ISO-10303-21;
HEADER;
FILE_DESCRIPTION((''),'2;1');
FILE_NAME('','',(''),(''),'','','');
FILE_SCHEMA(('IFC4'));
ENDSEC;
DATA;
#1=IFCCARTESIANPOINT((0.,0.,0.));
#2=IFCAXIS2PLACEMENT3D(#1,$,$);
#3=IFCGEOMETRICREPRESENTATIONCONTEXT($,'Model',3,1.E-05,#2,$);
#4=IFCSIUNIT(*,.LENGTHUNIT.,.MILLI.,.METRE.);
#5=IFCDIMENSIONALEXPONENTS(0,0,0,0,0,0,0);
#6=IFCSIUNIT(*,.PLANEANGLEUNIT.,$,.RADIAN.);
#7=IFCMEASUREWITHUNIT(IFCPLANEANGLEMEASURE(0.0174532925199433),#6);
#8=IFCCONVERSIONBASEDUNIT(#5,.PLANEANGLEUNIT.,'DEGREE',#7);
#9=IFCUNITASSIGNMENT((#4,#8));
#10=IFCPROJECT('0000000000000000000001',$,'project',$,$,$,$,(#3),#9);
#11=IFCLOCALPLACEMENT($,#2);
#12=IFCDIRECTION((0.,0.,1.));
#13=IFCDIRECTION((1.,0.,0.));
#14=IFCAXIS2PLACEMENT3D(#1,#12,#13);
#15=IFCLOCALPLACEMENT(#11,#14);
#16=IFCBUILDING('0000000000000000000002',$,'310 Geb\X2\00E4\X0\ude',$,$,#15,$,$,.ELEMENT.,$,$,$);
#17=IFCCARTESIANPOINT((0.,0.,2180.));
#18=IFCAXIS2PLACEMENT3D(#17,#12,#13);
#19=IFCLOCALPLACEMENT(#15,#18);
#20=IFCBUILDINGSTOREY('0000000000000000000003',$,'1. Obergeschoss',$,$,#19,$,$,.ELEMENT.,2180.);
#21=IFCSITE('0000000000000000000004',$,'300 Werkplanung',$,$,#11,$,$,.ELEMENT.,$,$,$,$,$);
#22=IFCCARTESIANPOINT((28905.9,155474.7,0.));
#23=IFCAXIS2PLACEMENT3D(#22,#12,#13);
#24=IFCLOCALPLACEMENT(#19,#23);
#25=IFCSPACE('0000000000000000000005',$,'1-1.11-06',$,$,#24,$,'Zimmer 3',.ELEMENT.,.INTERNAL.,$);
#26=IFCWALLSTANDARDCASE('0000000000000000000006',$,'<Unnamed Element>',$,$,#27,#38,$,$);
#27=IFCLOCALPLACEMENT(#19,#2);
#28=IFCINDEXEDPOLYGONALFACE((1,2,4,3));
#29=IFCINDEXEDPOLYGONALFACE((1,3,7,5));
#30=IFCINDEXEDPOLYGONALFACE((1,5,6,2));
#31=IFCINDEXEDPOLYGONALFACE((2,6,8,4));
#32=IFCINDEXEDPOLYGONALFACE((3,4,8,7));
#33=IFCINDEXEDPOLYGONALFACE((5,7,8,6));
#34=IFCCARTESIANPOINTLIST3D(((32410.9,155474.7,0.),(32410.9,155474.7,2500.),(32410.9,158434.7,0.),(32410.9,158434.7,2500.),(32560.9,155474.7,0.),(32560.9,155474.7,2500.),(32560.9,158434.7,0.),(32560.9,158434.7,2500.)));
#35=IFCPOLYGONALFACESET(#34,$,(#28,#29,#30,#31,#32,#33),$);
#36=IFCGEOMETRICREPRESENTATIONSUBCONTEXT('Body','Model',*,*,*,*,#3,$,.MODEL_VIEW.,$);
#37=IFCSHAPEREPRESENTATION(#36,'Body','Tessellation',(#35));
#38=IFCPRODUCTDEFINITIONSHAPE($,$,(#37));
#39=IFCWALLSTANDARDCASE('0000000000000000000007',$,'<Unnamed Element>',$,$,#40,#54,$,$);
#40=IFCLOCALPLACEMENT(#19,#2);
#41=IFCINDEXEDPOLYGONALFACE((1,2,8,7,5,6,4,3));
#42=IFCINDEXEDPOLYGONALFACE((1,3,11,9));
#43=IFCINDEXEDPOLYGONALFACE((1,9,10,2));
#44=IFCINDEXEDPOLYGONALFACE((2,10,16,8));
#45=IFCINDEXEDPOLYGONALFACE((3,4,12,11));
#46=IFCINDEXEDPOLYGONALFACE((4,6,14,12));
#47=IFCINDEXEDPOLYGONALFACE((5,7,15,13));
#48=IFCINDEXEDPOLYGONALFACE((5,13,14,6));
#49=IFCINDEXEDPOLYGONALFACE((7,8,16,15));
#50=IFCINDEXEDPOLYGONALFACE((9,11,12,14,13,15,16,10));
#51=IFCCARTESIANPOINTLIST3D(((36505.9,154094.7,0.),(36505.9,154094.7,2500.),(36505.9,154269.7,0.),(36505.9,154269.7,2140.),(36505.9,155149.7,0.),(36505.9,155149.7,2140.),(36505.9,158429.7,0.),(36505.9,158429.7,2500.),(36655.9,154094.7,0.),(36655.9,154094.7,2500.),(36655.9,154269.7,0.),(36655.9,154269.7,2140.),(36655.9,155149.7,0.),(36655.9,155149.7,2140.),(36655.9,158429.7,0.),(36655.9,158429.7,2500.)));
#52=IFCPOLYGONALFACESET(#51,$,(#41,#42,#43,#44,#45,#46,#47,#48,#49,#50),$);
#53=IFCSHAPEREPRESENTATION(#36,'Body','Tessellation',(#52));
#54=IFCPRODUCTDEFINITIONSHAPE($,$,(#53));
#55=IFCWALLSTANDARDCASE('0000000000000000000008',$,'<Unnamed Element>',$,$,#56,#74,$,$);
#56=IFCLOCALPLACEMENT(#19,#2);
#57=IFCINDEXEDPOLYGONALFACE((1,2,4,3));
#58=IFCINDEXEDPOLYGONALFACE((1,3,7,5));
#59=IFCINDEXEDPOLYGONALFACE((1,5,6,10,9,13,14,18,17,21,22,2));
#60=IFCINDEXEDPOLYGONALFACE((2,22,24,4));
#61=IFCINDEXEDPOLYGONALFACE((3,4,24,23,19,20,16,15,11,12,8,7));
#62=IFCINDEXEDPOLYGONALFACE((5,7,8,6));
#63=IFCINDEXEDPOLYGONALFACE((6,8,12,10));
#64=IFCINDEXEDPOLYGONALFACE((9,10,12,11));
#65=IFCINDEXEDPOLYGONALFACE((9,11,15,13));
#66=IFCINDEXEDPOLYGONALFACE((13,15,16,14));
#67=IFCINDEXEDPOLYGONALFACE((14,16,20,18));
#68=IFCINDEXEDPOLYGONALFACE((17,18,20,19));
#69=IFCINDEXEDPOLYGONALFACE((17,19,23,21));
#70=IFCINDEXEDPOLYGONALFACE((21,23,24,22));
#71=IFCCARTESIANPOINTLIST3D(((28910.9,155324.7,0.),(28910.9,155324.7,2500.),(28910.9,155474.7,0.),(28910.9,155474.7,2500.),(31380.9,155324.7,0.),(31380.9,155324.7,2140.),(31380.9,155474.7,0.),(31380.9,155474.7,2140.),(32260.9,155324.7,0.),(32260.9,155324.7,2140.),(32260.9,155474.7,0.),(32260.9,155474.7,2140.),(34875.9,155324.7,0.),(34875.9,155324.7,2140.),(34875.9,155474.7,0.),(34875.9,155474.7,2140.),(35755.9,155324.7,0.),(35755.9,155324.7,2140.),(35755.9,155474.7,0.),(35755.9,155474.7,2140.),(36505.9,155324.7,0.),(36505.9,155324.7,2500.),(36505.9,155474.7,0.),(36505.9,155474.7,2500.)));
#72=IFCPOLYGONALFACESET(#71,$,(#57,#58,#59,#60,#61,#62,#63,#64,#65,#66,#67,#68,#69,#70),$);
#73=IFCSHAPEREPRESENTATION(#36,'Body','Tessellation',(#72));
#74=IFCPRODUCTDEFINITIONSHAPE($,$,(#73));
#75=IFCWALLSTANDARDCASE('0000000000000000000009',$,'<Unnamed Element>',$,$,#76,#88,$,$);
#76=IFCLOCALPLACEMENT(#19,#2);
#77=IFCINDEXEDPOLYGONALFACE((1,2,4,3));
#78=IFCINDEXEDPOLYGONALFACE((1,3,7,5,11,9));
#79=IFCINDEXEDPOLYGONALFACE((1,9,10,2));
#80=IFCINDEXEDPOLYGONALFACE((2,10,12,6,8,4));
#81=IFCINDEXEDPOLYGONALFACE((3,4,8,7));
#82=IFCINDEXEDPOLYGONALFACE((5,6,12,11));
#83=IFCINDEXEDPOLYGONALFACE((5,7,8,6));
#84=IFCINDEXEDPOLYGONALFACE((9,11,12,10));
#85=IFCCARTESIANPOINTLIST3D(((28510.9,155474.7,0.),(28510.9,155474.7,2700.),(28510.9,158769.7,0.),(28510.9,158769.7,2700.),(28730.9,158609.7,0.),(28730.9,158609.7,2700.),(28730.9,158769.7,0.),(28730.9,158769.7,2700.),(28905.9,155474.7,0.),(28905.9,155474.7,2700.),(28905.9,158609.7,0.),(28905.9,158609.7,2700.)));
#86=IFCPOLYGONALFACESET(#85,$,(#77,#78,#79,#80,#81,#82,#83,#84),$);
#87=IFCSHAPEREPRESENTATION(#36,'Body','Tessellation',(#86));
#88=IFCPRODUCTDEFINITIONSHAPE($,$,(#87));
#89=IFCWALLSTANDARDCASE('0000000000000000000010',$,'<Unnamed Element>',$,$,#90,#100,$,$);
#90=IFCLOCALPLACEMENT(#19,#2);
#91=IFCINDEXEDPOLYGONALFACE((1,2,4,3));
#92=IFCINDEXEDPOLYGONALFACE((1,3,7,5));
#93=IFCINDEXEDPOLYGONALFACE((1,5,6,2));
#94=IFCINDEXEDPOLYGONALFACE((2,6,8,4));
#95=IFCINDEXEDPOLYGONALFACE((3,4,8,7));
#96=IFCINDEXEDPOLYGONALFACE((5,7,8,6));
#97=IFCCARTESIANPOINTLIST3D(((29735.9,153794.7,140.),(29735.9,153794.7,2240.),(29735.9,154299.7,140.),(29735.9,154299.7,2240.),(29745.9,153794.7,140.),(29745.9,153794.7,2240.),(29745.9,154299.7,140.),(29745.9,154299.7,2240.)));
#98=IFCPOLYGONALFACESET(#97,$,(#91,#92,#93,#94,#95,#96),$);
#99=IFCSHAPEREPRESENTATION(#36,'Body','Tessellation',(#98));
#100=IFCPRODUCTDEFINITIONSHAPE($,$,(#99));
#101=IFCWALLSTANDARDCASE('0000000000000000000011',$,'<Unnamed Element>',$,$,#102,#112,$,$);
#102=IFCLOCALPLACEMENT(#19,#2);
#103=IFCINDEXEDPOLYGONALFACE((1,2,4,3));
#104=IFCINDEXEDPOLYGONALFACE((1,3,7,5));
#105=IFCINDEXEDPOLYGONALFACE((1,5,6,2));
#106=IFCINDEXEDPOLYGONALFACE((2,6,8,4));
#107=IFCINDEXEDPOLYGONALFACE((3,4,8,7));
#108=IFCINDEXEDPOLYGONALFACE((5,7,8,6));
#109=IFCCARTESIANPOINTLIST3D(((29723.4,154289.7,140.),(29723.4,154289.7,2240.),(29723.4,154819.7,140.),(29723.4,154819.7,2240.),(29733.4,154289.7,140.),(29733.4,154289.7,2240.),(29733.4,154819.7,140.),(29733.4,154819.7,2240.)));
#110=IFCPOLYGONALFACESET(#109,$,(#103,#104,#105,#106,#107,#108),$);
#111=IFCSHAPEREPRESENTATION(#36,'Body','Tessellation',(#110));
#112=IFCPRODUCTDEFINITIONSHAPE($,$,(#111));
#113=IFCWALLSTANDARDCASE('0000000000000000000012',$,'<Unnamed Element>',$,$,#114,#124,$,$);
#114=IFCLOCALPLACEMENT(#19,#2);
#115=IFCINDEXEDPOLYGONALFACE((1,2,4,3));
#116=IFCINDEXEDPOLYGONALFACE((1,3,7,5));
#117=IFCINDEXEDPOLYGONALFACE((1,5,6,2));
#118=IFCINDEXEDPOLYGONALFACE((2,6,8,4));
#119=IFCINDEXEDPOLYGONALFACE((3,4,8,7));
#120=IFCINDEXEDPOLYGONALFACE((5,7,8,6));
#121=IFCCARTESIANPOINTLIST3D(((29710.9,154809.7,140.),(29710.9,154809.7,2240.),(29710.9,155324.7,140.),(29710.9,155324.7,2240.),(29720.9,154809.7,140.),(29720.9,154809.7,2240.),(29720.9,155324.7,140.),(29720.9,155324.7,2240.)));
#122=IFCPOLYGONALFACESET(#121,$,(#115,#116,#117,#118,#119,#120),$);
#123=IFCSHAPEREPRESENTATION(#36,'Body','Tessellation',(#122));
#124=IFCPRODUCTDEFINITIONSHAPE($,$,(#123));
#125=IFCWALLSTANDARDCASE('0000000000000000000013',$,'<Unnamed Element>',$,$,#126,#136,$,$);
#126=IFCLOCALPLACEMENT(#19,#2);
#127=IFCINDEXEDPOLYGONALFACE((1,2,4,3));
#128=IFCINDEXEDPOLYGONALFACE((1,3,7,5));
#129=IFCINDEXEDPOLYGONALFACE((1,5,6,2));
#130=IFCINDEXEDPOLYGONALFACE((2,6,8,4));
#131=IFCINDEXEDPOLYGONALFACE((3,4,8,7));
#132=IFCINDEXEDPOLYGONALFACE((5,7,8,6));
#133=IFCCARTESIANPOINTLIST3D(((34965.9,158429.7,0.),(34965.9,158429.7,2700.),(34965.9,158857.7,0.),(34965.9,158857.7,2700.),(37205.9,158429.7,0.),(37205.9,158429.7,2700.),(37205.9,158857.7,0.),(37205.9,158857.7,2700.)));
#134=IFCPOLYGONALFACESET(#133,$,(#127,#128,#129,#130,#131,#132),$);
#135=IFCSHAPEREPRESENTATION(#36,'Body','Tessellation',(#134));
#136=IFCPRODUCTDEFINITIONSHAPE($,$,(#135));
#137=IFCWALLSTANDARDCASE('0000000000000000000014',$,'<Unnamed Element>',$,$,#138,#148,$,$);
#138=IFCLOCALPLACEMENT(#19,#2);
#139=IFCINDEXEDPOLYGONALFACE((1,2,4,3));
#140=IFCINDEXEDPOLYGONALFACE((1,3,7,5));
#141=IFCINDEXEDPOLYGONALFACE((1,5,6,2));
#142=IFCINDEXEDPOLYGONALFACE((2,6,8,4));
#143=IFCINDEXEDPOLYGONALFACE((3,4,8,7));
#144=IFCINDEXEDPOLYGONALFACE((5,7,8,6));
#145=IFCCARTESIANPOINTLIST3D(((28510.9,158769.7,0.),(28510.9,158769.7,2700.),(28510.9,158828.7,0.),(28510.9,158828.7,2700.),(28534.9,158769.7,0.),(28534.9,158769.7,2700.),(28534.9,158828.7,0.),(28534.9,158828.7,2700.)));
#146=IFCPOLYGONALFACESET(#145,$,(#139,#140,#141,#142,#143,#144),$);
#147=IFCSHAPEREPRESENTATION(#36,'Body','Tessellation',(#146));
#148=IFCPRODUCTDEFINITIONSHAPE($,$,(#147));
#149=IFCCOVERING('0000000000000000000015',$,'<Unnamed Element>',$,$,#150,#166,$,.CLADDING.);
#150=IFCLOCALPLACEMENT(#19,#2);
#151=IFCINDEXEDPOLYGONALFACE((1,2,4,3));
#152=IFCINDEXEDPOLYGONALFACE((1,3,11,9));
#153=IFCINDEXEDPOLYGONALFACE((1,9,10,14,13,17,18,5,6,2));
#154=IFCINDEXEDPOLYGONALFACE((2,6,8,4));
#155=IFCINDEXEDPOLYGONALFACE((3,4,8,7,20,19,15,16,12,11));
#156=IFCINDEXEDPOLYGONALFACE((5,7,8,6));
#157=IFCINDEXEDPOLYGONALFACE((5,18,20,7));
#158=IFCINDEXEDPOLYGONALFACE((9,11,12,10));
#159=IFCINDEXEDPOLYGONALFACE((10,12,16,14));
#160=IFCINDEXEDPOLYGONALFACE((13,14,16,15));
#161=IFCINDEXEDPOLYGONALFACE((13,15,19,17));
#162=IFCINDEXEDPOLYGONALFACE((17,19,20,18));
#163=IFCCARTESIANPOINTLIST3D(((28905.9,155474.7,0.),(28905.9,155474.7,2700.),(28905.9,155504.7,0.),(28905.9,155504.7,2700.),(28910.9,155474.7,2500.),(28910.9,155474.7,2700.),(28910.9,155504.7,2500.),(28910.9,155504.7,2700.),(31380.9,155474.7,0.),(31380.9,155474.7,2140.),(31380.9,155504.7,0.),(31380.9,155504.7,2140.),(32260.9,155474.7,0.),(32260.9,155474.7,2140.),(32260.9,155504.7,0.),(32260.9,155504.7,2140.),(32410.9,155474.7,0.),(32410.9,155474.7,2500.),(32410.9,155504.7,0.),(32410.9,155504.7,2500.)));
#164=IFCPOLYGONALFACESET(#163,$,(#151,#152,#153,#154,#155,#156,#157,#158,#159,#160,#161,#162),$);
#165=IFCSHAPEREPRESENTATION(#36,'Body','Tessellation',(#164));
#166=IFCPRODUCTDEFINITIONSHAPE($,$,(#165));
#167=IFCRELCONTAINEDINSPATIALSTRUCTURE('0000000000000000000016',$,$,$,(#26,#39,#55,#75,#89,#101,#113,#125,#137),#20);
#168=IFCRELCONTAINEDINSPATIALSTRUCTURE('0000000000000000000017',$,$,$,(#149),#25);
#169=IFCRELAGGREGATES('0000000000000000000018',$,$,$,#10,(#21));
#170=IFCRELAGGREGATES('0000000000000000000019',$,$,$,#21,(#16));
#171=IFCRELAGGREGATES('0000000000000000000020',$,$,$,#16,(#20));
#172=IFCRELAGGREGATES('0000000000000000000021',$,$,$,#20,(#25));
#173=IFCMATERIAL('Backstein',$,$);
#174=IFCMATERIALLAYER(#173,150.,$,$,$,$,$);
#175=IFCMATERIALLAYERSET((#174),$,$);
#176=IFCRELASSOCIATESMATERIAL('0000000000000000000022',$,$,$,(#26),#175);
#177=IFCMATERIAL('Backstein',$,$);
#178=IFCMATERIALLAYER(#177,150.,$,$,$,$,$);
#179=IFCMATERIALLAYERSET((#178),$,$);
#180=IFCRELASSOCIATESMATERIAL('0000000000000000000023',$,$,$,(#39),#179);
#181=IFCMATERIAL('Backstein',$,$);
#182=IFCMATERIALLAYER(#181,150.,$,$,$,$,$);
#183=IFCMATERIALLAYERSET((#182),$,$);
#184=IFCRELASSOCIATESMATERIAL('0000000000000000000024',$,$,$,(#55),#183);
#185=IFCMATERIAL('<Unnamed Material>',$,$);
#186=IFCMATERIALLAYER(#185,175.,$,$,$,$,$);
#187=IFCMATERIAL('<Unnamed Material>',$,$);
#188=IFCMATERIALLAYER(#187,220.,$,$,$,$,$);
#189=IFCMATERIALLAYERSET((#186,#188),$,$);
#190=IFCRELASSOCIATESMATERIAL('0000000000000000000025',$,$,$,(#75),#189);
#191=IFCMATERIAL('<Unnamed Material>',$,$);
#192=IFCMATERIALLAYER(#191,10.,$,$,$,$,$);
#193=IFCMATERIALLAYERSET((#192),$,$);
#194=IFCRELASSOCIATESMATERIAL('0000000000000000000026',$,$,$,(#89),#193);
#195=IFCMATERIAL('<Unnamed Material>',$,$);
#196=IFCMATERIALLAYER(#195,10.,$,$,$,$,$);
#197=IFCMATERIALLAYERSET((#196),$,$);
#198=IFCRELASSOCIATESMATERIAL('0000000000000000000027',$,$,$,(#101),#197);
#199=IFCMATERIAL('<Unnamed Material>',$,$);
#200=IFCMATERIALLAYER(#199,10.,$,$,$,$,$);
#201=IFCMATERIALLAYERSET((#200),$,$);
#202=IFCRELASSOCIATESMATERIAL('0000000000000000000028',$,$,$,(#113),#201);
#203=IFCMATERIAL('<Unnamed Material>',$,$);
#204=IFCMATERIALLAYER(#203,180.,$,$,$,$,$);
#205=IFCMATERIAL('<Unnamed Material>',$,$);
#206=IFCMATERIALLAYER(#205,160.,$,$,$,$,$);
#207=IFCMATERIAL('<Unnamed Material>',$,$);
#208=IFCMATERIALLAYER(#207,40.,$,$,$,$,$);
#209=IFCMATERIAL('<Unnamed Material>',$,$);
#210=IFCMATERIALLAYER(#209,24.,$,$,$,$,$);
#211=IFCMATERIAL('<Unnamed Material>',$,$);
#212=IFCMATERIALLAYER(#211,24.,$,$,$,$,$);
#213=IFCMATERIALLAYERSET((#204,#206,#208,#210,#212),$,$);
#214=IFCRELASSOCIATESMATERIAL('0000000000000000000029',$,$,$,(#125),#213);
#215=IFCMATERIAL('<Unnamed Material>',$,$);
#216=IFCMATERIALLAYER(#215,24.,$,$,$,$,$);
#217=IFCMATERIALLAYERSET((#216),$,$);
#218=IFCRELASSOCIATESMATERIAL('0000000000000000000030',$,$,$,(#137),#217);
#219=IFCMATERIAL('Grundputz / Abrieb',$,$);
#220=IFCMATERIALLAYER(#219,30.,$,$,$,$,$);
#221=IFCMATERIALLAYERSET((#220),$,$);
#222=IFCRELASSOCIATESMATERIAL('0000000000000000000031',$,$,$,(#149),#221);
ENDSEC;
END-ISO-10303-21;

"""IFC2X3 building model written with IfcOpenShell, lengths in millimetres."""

from ifc_helpers import new_model, entity, si_unit, converted_unit, frame, frame_2d, origin, origin_with_axes, place, context, subcontext, project, spatial, polyline, rectangle, outline, extrude, material, layer, layer_set, layer_usage, element, save


model = new_model("IFC2X3")

# Units and contexts
model_context = context("Model", 3, precision=1e-05, world=origin())
body_context = subcontext(model_context, "Body", "Model", "MODEL_VIEW")
ifc_project = project(units=[si_unit("LENGTHUNIT", "METRE", prefix="MILLI"), converted_unit("PLANEANGLEUNIT", "DEGREE", entity("IfcPlaneAngleMeasure", 0.0174532925199433), si_unit("PLANEANGLEUNIT", "RADIAN"), dimensions=[0, 0, 0, 0, 0, 0, 0])], contexts=[model_context])

# Site, building, storey
site_placement = place(None, origin())
site = spatial("IfcSite", under=ifc_project, at=site_placement, Name="300 Werkplanung", CompositionType="ELEMENT")
building_placement = place(site_placement, origin_with_axes())
building = spatial("IfcBuilding", under=site, at=building_placement, Name="310 Gebäude", CompositionType="ELEMENT")
storey_placement = place(building_placement, frame((0.0, 0.0, 2180.0), z_axis=(0.0, 0.0, 1.0), x_axis=(1.0, 0.0, 0.0)))
storey = spatial("IfcBuildingStorey", under=building, at=storey_placement, Name="1. Obergeschoss", CompositionType="ELEMENT", Elevation=2180.0)

# Wall
ifc_material_1 = material(Name="Backstein")
ifc_layer_1 = layer(ifc_material_1, 150.0)
ifc_layer_set_1 = layer_set([ifc_layer_1])
ifc_layer_usage_1 = layer_usage(ifc_layer_set_1, "AXIS2", "POSITIVE", 0.0)
wall_1_placement = place(storey_placement, frame((32410.9, 158434.7, 0.0), z_axis=(0.0, 0.0, 1.0), x_axis=(0.0, -1.0, 0.0)))
element("IfcWallStandardCase", 1, at=wall_1_placement, inside=storey, material=ifc_layer_usage_1, Name="<Unnamed Element>", context=body_context, shape_type="SweptSolid", body=[
    extrude(rectangle(XDim=2960.0, YDim=150.0, at=frame_2d((1480.0, 75.0), x_axis=(1.0, 0.0))), origin_with_axes(), (0.0, 0.0, 1.0), 2500.0),
])

# Wall, opening
ifc_material_2 = material(Name="Backstein")
ifc_layer_2 = layer(ifc_material_2, 150.0)
ifc_layer_set_2 = layer_set([ifc_layer_2])
ifc_layer_usage_2 = layer_usage(ifc_layer_set_2, "AXIS2", "POSITIVE", 0.0)
wall_2_placement = place(storey_placement, frame((36655.9, 154094.7, 0.0), z_axis=(0.0, 0.0, 1.0), x_axis=(0.0, 1.0, 0.0)))
wall_2 = element("IfcWallStandardCase", 2, at=wall_2_placement, inside=storey, material=ifc_layer_usage_2, Name="<Unnamed Element>", context=body_context, shape_type="SweptSolid", body=[
    extrude(rectangle(XDim=4335.0, YDim=150.0, at=frame_2d((2167.5, 75.0), x_axis=(1.0, 0.0))), origin_with_axes(), (0.0, 0.0, 1.0), 2500.0),
])
opening_1_placement = place(wall_2_placement, frame((175.0, 0.0, 0.0), z_axis=(0.0, 1.0, 0.0), x_axis=(0.0, 0.0, 1.0)))
element("IfcOpeningElement", 3, at=opening_1_placement, cuts=wall_2, ObjectType="Opening", context=body_context, shape_type="SweptSolid", body=[
    extrude(rectangle(XDim=2140.0, YDim=880.0, at=frame_2d((1070.0, 440.0), x_axis=(1.0, 0.0))), origin_with_axes(), (0.0, 0.0, 1.0), 150.0),
])

# Wall, openings
ifc_material_3 = material(Name="Backstein")
ifc_layer_3 = layer(ifc_material_3, 150.0)
ifc_layer_set_3 = layer_set([ifc_layer_3])
ifc_layer_usage_3 = layer_usage(ifc_layer_set_3, "AXIS2", "POSITIVE", 0.0)
wall_3_placement = place(storey_placement, frame((28910.9, 155324.7, 0.0), z_axis=(0.0, 0.0, 1.0), x_axis=(1.0, 0.0, 0.0)))
wall_3 = element("IfcWallStandardCase", 4, at=wall_3_placement, inside=storey, material=ifc_layer_usage_3, Name="<Unnamed Element>", context=body_context, shape_type="SweptSolid", body=[
    extrude(rectangle(XDim=7595.0, YDim=150.0, at=frame_2d((3797.5, 75.0), x_axis=(1.0, 0.0))), origin_with_axes(), (0.0, 0.0, 1.0), 2500.0),
])
opening_2_placement = place(wall_3_placement, frame((2470.0, 0.0, 0.0), z_axis=(0.0, 1.0, 0.0), x_axis=(0.0, 0.0, 1.0)))
element("IfcOpeningElement", 5, at=opening_2_placement, cuts=wall_3, ObjectType="Opening", context=body_context, shape_type="SweptSolid", body=[
    extrude(rectangle(XDim=2140.0, YDim=880.0, at=frame_2d((1070.0, 440.0), x_axis=(1.0, 0.0))), origin_with_axes(), (0.0, 0.0, 1.0), 150.0),
])
opening_3_placement = place(wall_3_placement, frame((5965.0, 0.0, 0.0), z_axis=(0.0, 1.0, 0.0), x_axis=(0.0, 0.0, 1.0)))
element("IfcOpeningElement", 6, at=opening_3_placement, cuts=wall_3, ObjectType="Opening", context=body_context, shape_type="SweptSolid", body=[
    extrude(rectangle(XDim=2140.0, YDim=880.0, at=frame_2d((1070.0, 440.0), x_axis=(1.0, 0.0))), origin_with_axes(), (0.0, 0.0, 1.0), 150.0),
])

# Walls
ifc_material_4 = material(Name="<Unnamed Material>")
ifc_layer_4 = layer(ifc_material_4, 175.0)
ifc_material_5 = material(Name="<Unnamed Material>")
ifc_layer_5 = layer(ifc_material_5, 220.0)
ifc_layer_set_4 = layer_set([ifc_layer_4, ifc_layer_5])
ifc_layer_usage_4 = layer_usage(ifc_layer_set_4, "AXIS2", "POSITIVE", -175.0)
wall_4_placement = place(storey_placement, frame((28905.9, 155474.7, 0.0), z_axis=(0.0, 0.0, 1.0), x_axis=(0.0, 1.0, 0.0)))
element("IfcWallStandardCase", 7, at=wall_4_placement, inside=storey, material=ifc_layer_usage_4, Name="<Unnamed Element>", context=body_context, shape_type="SweptSolid", body=[
    extrude(outline(polyline([(0.0, 0.0), (3135.0, 0.0), (3135.0, 175.0), (3295.0, 175.0), (3295.0, 395.0), (0.0, 395.0), (0.0, 0.0)])), origin_with_axes(), (0.0, 0.0, 1.0), 2700.0),
])
ifc_material_6 = material(Name="<Unnamed Material>")
ifc_layer_6 = layer(ifc_material_6, 10.0)
ifc_layer_set_5 = layer_set([ifc_layer_6])
ifc_layer_usage_5 = layer_usage(ifc_layer_set_5, "AXIS2", "POSITIVE", 0.0)
wall_5_placement = place(storey_placement, frame((29735.9, 154299.7, 140.0), z_axis=(0.0, 0.0, 1.0), x_axis=(0.0, -1.0, 0.0)))
element("IfcWallStandardCase", 8, at=wall_5_placement, inside=storey, material=ifc_layer_usage_5, Name="<Unnamed Element>", context=body_context, shape_type="SweptSolid", body=[
    extrude(rectangle(XDim=505.0, YDim=10.0, at=frame_2d((252.5, 5.0), x_axis=(1.0, 0.0))), origin_with_axes(), (0.0, 0.0, 1.0), 2100.0),
])
ifc_material_7 = material(Name="<Unnamed Material>")
ifc_layer_7 = layer(ifc_material_7, 10.0)
ifc_layer_set_6 = layer_set([ifc_layer_7])
ifc_layer_usage_6 = layer_usage(ifc_layer_set_6, "AXIS2", "POSITIVE", 0.0)
wall_6_placement = place(storey_placement, frame((29723.4, 154819.7, 140.0), z_axis=(0.0, 0.0, 1.0), x_axis=(0.0, -1.0, 0.0)))
element("IfcWallStandardCase", 9, at=wall_6_placement, inside=storey, material=ifc_layer_usage_6, Name="<Unnamed Element>", context=body_context, shape_type="SweptSolid", body=[
    extrude(rectangle(XDim=530.0, YDim=10.0, at=frame_2d((265.0, 5.0), x_axis=(1.0, 0.0))), origin_with_axes(), (0.0, 0.0, 1.0), 2100.0),
])
ifc_material_8 = material(Name="<Unnamed Material>")
ifc_layer_8 = layer(ifc_material_8, 10.0)
ifc_layer_set_7 = layer_set([ifc_layer_8])
ifc_layer_usage_7 = layer_usage(ifc_layer_set_7, "AXIS2", "POSITIVE", 0.0)
wall_7_placement = place(storey_placement, frame((29710.9, 155324.7, 140.0), z_axis=(0.0, 0.0, 1.0), x_axis=(0.0, -1.0, 0.0)))
element("IfcWallStandardCase", 10, at=wall_7_placement, inside=storey, material=ifc_layer_usage_7, Name="<Unnamed Element>", context=body_context, shape_type="SweptSolid", body=[
    extrude(rectangle(XDim=515.0, YDim=10.0, at=frame_2d((257.5, 5.0), x_axis=(1.0, 0.0))), origin_with_axes(), (0.0, 0.0, 1.0), 2100.0),
])
ifc_material_9 = material(Name="<Unnamed Material>")
ifc_layer_9 = layer(ifc_material_9, 180.0)
ifc_material_10 = material(Name="<Unnamed Material>")
ifc_layer_10 = layer(ifc_material_10, 160.0)
ifc_material_11 = material(Name="<Unnamed Material>")
ifc_layer_11 = layer(ifc_material_11, 40.0)
ifc_material_12 = material(Name="<Unnamed Material>")
ifc_layer_12 = layer(ifc_material_12, 24.0)
ifc_material_13 = material(Name="<Unnamed Material>")
ifc_layer_13 = layer(ifc_material_13, 24.0)
ifc_layer_set_8 = layer_set([ifc_layer_9, ifc_layer_10, ifc_layer_11, ifc_layer_12, ifc_layer_13])
ifc_layer_usage_8 = layer_usage(ifc_layer_set_8, "AXIS2", "POSITIVE", -175.0)
wall_8_placement = place(storey_placement, frame((34965.9, 158429.7, 0.0), z_axis=(0.0, 0.0, 1.0), x_axis=(1.0, 0.0, 0.0)))
element("IfcWallStandardCase", 11, at=wall_8_placement, inside=storey, material=ifc_layer_usage_8, Name="<Unnamed Element>", context=body_context, shape_type="SweptSolid", body=[
    extrude(rectangle(XDim=2240.0, YDim=428.0, at=frame_2d((1120.0, 214.0), x_axis=(1.0, 0.0))), origin_with_axes(), (0.0, 0.0, 1.0), 2700.0),
])
ifc_material_14 = material(Name="<Unnamed Material>")
ifc_layer_14 = layer(ifc_material_14, 24.0)
ifc_layer_set_9 = layer_set([ifc_layer_14])
ifc_layer_usage_9 = layer_usage(ifc_layer_set_9, "AXIS2", "POSITIVE", 0.0)
wall_9_placement = place(storey_placement, frame((28510.9, 158828.7, 0.0), z_axis=(0.0, 0.0, 1.0), x_axis=(0.0, -1.0, 0.0)))
element("IfcWallStandardCase", 12, at=wall_9_placement, inside=storey, material=ifc_layer_usage_9, Name="<Unnamed Element>", context=body_context, shape_type="SweptSolid", body=[
    extrude(rectangle(XDim=59.0, YDim=24.0, at=frame_2d((29.5, 12.0), x_axis=(1.0, 0.0))), origin_with_axes(), (0.0, 0.0, 1.0), 2700.0),
])

# Shared definitions
space_1_placement = place(storey_placement, frame((28905.9, 155474.7, 0.0), z_axis=(0.0, 0.0, 1.0), x_axis=(1.0, 0.0, 0.0)))
space_1 = spatial("IfcSpace", under=storey, at=space_1_placement, Name="1-1.11-06", LongName="Zimmer 3", CompositionType="ELEMENT", InteriorOrExteriorSpace="INTERNAL")

# Covering
ifc_material_15 = material(Name="Grundputz / Abrieb")
ifc_layer_15 = layer(ifc_material_15, 30.0)
ifc_layer_set_10 = layer_set([ifc_layer_15])
ifc_layer_usage_10 = layer_usage(ifc_layer_set_10, "AXIS3", "POSITIVE", 0.0)
covering_1_placement = place(space_1_placement, frame((0.0, 0.0, 0.0), z_axis=(0.0, 0.0, 1.0), x_axis=(1.0, 0.0, 0.0)))
element("IfcCovering", 13, at=covering_1_placement, inside=space_1, material=ifc_layer_usage_10, Name="<Unnamed Element>", PredefinedType="CLADDING", context=body_context, shape_type="SweptSolid", body=[
    extrude(outline(polyline([(3505.0, 0.0), (3505.0, -2500.0), (5.0, -2500.0), (5.0, -2700.0), (0.0, -2700.0), (0.0, 0.0), (2475.0, 0.0), (2475.0, -2140.0), (3355.0, -2140.0), (3355.0, 0.0), (3505.0, 0.0)])), frame((0.0, 0.0, 0.0), z_axis=(0.0, 1.0, 0.0), x_axis=(1.0, 0.0, 0.0)), (0.0, 0.0, 1.0), 30.0),
])

save(model, "model.ifc")
